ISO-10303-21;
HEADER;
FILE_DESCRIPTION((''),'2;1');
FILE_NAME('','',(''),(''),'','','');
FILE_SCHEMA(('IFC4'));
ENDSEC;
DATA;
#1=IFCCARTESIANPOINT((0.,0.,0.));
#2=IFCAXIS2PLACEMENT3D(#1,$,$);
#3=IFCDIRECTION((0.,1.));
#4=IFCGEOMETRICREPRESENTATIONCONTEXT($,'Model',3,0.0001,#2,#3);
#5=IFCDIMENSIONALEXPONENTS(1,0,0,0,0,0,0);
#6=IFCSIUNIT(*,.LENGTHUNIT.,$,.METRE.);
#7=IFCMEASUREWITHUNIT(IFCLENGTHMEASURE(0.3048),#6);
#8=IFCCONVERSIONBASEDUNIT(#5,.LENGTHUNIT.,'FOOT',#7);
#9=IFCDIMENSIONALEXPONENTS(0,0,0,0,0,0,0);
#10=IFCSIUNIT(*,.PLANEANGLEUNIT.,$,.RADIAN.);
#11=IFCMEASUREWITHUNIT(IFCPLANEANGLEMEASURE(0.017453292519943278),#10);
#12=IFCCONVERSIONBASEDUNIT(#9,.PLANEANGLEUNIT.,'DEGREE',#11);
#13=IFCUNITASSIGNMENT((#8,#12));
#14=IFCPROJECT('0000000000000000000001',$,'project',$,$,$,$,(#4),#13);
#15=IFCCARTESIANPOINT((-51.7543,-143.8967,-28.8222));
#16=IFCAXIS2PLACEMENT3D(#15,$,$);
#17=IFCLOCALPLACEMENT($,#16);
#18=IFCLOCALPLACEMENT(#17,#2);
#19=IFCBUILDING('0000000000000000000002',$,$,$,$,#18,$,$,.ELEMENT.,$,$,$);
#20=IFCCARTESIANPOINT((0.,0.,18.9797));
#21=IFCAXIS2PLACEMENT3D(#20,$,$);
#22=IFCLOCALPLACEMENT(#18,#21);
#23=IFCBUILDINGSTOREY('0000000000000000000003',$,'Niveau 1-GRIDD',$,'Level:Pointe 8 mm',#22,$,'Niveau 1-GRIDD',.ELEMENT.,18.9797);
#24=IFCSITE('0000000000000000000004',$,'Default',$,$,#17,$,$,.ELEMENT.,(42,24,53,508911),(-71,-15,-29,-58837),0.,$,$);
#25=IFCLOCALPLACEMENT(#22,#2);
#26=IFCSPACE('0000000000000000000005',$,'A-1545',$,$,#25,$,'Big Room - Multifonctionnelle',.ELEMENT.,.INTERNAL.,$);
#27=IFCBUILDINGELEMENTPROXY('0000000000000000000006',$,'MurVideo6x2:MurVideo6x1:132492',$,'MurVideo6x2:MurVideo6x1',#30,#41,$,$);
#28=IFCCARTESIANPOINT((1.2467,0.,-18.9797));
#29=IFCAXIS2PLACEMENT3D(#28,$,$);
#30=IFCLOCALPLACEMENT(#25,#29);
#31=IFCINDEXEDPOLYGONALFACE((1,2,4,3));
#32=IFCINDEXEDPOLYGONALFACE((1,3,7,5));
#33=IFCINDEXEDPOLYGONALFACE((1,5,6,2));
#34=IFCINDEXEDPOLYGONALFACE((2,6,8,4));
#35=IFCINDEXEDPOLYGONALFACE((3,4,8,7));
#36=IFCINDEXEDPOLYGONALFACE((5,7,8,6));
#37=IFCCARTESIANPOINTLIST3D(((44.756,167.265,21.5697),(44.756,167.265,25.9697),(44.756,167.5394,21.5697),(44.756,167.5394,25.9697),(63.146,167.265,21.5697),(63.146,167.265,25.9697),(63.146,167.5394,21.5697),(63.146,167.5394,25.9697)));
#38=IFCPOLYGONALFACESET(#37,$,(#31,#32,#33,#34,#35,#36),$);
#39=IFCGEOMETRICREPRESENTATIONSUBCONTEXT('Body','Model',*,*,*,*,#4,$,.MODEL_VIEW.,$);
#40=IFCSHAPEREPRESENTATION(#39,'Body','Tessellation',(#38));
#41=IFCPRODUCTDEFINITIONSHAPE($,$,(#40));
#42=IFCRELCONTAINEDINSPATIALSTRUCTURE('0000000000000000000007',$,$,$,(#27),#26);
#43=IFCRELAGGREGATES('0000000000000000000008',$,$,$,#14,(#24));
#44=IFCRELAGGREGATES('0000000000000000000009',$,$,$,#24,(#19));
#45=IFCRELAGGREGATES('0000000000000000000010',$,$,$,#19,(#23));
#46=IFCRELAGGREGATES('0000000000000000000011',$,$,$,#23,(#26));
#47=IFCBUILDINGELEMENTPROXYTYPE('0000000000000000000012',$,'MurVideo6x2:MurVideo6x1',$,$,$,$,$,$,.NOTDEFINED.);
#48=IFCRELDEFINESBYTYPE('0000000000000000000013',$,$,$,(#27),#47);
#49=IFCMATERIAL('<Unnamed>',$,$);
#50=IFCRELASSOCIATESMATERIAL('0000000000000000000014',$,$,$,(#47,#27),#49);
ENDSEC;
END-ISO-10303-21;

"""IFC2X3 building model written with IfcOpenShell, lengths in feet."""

from ifc_helpers import new_model, entity, si_unit, converted_unit, direction, frame, frame_2d, origin, place, context, subcontext, project, spatial, rectangle, extrude, source, transform, mapped, material, type_object, type_shapes, element, save


model = new_model("IFC2X3")

# Units and contexts
model_context = context("Model", 3, precision=0.0001, world=origin(), true_north=direction((0.0, 1.0)))
body_context = subcontext(model_context, "Body", "Model", "MODEL_VIEW")
ifc_project = project(units=[converted_unit("LENGTHUNIT", "FOOT", entity("IfcLengthMeasure", 0.3048), si_unit("LENGTHUNIT", "METRE"), dimensions=[1, 0, 0, 0, 0, 0, 0]), converted_unit("PLANEANGLEUNIT", "DEGREE", entity("IfcPlaneAngleMeasure", 0.017453292519943278), si_unit("PLANEANGLEUNIT", "RADIAN"), dimensions=[0, 0, 0, 0, 0, 0, 0])], contexts=[model_context])

# Site, building, storey
site_placement = place(None, frame((-51.7543, -143.8967, -28.8222)))
site = spatial("IfcSite", under=ifc_project, at=site_placement, Name="Default", CompositionType="ELEMENT", RefLatitude=(42, 24, 53, 508911), RefLongitude=(-71, -15, -29, -58837), RefElevation=0.0)
building_placement = place(site_placement, origin())
building = spatial("IfcBuilding", under=site, at=building_placement, CompositionType="ELEMENT")
storey_placement = place(building_placement, frame((0.0, 0.0, 18.9797)))
storey = spatial("IfcBuildingStorey", under=building, at=storey_placement, Name="Niveau 1-GRIDD", ObjectType="Level:Pointe 8 mm", LongName="Niveau 1-GRIDD", CompositionType="ELEMENT", Elevation=18.9797)

# Shared definitions
ifc_material_1 = material(Name="<Unnamed>")

# Shared definitions
space_1_placement = place(storey_placement, origin())
space_1 = spatial("IfcSpace", under=storey, at=space_1_placement, Name="A-1545", LongName="Big Room - Multifonctionnelle", CompositionType="ELEMENT", InteriorOrExteriorSpace="INTERNAL")

# Building element proxy
building_element_proxy_type = type_object("IfcBuildingElementProxyType", Name="MurVideo6x2:MurVideo6x1", PredefinedType="NOTDEFINED", material=ifc_material_1)
shared_shape_1 = source(origin(), body_context, "Body", "SweptSolid", [
    extrude(rectangle(XDim=0.2744, YDim=18.39, at=frame_2d((0.0, 0.0), x_axis=(1.0, 0.0))), frame((53.951, 167.4022, 21.5697), z_axis=(0.0, 0.0, 1.0), x_axis=(0.0, 1.0, 0.0)), (0.0, 0.0, 1.0), 4.4),
])
type_shapes(building_element_proxy_type, [shared_shape_1])
proxy_placement = place(space_1_placement, frame((1.2467, 0.0, -18.9797)))
element("IfcBuildingElementProxy", 1, at=proxy_placement, inside=space_1, type_object=building_element_proxy_type, material=ifc_material_1, Name="MurVideo6x2:MurVideo6x1:132492", ObjectType="MurVideo6x2:MurVideo6x1", context=body_context, shape_type="MappedRepresentation", body=[
    mapped(shared_shape_1, transform((0.0, 0.0, 0.0), scale=1.0)),
])

save(model, "model.ifc")
